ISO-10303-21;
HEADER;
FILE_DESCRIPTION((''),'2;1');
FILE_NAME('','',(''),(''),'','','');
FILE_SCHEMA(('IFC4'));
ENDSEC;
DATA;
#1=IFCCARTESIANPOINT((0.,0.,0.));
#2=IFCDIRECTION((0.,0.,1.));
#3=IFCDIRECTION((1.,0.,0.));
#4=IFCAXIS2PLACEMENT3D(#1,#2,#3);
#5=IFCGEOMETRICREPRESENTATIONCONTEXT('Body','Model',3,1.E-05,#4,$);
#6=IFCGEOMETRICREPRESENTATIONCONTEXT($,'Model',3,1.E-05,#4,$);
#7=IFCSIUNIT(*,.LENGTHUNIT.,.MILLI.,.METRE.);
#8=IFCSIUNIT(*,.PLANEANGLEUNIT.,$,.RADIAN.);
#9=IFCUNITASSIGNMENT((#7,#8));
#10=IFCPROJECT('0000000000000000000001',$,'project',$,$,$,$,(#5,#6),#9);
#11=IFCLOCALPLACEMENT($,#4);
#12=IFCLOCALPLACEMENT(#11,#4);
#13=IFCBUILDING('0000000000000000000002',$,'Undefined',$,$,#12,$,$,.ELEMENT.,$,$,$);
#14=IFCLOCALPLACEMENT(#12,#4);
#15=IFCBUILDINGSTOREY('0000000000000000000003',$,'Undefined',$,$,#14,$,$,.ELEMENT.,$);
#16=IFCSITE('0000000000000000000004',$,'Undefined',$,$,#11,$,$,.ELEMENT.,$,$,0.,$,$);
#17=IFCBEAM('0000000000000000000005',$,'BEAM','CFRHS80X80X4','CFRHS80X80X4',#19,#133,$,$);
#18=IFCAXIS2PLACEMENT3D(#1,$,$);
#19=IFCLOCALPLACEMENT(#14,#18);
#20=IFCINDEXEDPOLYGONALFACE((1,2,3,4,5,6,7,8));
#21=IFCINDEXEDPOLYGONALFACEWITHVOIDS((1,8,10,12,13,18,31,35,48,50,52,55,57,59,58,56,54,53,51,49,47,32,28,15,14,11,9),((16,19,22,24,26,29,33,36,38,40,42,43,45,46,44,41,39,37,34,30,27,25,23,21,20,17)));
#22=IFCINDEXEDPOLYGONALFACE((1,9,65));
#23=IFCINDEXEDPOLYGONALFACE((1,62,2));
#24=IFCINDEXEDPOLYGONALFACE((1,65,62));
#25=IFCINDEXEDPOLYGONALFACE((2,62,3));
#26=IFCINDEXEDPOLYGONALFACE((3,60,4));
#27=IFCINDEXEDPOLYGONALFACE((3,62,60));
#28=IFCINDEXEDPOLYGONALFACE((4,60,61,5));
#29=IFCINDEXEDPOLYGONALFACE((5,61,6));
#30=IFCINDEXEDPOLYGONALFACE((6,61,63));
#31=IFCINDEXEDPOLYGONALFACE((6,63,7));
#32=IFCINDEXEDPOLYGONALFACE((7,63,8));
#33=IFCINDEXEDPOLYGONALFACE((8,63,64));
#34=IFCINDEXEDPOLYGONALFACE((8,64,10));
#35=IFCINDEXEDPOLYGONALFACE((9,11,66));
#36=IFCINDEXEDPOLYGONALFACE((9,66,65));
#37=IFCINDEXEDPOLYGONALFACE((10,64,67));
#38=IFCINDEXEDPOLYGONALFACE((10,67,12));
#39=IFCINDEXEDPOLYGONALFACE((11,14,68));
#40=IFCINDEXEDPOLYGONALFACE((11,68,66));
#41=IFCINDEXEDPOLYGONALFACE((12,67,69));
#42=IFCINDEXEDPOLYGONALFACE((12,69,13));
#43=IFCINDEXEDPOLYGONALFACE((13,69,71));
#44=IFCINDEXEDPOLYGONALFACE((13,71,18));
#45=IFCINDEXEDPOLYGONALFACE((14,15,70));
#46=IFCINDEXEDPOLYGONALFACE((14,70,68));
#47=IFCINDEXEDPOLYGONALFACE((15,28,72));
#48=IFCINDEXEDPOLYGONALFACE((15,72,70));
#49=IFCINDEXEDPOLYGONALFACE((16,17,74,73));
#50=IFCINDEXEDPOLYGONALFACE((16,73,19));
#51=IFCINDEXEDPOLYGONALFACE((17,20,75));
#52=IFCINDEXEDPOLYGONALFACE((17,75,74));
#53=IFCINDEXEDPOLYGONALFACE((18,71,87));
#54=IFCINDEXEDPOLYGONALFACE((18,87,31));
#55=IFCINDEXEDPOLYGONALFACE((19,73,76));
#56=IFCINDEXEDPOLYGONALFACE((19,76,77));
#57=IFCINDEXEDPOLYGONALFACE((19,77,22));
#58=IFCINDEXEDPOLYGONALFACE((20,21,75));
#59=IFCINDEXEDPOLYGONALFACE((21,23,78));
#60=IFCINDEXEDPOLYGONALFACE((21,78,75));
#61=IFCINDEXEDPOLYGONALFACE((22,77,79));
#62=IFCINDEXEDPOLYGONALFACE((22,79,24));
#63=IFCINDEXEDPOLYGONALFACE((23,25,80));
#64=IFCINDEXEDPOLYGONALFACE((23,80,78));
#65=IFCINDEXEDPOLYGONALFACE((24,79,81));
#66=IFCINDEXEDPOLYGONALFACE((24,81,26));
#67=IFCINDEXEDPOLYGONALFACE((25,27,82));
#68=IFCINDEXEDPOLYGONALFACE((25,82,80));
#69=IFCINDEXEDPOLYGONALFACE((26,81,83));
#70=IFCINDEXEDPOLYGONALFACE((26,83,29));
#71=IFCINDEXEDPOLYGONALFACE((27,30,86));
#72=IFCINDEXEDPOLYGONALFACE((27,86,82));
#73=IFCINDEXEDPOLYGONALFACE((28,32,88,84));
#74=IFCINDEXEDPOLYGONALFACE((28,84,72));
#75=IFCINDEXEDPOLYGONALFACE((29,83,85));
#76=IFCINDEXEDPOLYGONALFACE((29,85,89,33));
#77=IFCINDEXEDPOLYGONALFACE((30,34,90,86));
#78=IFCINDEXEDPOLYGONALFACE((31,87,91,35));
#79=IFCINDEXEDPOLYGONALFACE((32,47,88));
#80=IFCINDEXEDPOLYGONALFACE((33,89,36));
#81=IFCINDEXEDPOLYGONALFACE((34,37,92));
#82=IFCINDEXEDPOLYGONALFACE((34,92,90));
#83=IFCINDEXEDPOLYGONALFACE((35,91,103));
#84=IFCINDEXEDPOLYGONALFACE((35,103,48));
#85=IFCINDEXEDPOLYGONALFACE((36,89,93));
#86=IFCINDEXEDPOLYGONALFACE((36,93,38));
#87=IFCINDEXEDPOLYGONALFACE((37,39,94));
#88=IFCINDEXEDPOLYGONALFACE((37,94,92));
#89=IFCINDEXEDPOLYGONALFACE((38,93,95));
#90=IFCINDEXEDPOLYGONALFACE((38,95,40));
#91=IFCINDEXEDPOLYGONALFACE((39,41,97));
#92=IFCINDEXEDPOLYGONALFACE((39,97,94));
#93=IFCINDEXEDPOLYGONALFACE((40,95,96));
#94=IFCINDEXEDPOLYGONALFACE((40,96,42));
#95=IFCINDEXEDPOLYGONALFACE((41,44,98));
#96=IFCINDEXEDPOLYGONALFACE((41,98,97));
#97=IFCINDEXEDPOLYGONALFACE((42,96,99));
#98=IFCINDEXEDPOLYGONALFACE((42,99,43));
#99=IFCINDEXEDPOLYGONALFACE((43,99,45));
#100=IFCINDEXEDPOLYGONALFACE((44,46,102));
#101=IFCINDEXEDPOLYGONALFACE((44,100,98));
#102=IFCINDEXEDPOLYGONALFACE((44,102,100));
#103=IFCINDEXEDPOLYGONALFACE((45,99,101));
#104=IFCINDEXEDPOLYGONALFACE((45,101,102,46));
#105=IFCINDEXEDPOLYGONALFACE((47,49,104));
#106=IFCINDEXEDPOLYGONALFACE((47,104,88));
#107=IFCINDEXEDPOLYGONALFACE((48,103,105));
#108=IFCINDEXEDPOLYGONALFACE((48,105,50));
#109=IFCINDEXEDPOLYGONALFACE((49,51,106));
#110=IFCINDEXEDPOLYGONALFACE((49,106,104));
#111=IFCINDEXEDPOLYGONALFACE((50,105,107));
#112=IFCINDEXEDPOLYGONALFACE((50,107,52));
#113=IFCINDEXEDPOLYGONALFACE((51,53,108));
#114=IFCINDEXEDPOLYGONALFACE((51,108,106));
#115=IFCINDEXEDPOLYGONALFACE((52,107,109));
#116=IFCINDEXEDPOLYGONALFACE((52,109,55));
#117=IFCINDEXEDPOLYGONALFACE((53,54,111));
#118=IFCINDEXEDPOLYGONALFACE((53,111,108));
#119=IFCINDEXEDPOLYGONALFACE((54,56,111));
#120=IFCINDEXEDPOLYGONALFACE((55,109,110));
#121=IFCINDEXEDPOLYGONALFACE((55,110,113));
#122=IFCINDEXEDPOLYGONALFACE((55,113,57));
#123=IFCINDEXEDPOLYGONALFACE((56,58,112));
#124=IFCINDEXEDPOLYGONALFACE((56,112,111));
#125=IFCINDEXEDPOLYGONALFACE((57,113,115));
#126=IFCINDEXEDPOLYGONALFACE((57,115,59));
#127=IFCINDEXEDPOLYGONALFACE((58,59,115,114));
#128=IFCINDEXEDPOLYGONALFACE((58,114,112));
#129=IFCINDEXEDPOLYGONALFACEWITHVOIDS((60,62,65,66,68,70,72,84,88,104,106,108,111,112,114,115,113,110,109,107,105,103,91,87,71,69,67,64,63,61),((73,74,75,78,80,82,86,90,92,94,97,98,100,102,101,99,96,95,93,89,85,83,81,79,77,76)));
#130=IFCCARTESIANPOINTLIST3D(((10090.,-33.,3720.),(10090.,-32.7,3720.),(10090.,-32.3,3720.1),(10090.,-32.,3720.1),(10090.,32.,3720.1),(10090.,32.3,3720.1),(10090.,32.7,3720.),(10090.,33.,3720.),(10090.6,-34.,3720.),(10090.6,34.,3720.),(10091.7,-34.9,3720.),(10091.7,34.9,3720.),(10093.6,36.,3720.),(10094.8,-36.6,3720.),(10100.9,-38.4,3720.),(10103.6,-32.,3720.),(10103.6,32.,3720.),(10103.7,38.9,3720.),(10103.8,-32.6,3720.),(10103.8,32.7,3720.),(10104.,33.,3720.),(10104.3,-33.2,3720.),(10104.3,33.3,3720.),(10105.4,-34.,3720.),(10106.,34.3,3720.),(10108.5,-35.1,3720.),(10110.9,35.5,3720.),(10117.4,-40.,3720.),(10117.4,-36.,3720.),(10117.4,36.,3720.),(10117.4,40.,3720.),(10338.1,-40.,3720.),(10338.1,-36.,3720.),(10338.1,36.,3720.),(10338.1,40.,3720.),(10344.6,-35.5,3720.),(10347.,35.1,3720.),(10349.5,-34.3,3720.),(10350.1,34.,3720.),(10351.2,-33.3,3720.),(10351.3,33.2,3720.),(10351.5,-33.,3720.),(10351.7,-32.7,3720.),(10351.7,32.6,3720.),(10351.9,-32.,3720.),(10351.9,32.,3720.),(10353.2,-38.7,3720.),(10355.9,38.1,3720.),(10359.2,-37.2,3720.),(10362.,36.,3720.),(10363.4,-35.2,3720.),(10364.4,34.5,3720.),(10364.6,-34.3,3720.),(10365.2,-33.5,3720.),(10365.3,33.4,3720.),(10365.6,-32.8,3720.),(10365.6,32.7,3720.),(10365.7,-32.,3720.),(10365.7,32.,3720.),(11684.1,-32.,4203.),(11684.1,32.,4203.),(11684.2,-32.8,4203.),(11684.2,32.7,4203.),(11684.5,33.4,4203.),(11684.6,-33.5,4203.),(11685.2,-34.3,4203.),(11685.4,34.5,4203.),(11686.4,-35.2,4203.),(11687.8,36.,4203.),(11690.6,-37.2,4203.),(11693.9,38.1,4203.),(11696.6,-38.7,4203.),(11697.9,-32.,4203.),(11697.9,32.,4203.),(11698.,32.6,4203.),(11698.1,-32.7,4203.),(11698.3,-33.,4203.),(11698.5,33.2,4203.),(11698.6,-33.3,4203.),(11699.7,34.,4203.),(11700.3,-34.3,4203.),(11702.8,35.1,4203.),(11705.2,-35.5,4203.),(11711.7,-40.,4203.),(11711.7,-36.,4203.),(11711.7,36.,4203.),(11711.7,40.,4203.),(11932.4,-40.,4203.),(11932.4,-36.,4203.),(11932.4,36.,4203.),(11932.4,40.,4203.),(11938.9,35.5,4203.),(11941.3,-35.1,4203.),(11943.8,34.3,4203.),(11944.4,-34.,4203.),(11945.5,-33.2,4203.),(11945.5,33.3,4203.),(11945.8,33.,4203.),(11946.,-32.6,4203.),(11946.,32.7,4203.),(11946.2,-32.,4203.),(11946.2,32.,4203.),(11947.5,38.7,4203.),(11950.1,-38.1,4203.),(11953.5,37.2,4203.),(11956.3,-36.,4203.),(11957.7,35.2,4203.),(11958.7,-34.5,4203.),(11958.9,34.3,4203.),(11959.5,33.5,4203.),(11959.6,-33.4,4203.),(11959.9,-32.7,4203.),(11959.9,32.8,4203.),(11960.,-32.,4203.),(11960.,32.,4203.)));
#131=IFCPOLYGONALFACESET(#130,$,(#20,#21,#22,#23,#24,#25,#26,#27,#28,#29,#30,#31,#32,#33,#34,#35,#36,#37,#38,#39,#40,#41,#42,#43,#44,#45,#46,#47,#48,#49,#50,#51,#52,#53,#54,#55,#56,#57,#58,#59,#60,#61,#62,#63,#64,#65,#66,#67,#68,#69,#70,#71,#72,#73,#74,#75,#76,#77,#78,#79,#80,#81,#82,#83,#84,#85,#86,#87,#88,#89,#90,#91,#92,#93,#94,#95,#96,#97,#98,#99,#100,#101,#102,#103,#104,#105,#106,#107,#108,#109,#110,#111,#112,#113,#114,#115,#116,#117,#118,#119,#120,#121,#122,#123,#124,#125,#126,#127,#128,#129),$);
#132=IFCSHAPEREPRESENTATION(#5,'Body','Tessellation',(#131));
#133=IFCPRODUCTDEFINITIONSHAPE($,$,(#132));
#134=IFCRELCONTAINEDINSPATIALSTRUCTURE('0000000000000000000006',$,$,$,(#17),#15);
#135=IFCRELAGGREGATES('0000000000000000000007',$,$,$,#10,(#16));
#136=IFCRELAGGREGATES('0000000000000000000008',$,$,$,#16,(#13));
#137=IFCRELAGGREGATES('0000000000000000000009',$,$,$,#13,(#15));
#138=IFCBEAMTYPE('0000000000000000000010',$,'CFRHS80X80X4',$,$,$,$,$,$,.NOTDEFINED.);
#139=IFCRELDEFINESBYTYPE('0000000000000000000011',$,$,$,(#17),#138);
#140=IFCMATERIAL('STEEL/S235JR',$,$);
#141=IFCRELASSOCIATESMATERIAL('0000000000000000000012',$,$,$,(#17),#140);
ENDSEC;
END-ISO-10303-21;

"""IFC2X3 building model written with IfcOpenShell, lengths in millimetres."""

from ifc_helpers import new_model, si_unit, frame, origin_with_axes, origin_2d_with_axis, place, context, project, spatial, hollow_rectangle, extrude, clip, halfspace, material, type_object, element, save


model = new_model("IFC2X3")

# Units and contexts
model_context_1 = context("Model", 3, precision=1e-05, world=origin_with_axes(), identifier="Body")
model_context_2 = context("Model", 3, precision=1e-05, world=origin_with_axes())
ifc_project = project(units=[si_unit("LENGTHUNIT", "METRE", prefix="MILLI"), si_unit("PLANEANGLEUNIT", "RADIAN")], contexts=[model_context_1, model_context_2])

# Site, building, storey
site_placement = place(None, origin_with_axes())
site = spatial("IfcSite", under=ifc_project, at=site_placement, Name="Undefined", CompositionType="ELEMENT", RefElevation=0.0)
building_placement = place(site_placement, origin_with_axes())
building = spatial("IfcBuilding", under=site, at=building_placement, Name="Undefined", CompositionType="ELEMENT")
storey_placement = place(building_placement, origin_with_axes())
storey = spatial("IfcBuildingStorey", under=building, at=storey_placement, Name="Undefined", CompositionType="ELEMENT")

# Shared definitions
ifc_material = material(Name="STEEL/S235JR")

# Beam
beam_type_1 = type_object("IfcBeamType", Name="CFRHS80X80X4", PredefinedType="NOTDEFINED")
beam_1_placement = place(storey_placement, frame((11948.4, 0.0, 4241.3), z_axis=(0.0, -1.0, 0.0), x_axis=(-0.957044, 0.0, -0.289943)))
element("IfcBeam", 1, at=beam_1_placement, inside=storey, type_object=beam_type_1, material=ifc_material, Name="BEAM", Description="CFRHS80X80X4", ObjectType="CFRHS80X80X4", context=model_context_1, shape_type="Clipping", body=[
    clip(clip(extrude(hollow_rectangle(XDim=80.0, YDim=80.0, WallThickness=4.0, InnerFilletRadius=4.0, OuterFilletRadius=8.0, at=origin_2d_with_axis()), frame((1929.7, 0.0, 0.0), z_axis=(-1.0, 0.0, 0.0), x_axis=(0.0, -1.0, 0.0)), (0.0, 0.0, 1.0), 1929.7), halfspace(frame((1929.9, -40.0, -40.0), z_axis=(0.289943, 0.957044, 0.0), x_axis=(0.0, 0.0, 1.0)), False)), halfspace(frame((0.0, 40.0, -40.0), z_axis=(-0.289943, -0.957044, 0.0), x_axis=(0.0, 0.0, 1.0)), False)),
])

save(model, "model.ifc")
